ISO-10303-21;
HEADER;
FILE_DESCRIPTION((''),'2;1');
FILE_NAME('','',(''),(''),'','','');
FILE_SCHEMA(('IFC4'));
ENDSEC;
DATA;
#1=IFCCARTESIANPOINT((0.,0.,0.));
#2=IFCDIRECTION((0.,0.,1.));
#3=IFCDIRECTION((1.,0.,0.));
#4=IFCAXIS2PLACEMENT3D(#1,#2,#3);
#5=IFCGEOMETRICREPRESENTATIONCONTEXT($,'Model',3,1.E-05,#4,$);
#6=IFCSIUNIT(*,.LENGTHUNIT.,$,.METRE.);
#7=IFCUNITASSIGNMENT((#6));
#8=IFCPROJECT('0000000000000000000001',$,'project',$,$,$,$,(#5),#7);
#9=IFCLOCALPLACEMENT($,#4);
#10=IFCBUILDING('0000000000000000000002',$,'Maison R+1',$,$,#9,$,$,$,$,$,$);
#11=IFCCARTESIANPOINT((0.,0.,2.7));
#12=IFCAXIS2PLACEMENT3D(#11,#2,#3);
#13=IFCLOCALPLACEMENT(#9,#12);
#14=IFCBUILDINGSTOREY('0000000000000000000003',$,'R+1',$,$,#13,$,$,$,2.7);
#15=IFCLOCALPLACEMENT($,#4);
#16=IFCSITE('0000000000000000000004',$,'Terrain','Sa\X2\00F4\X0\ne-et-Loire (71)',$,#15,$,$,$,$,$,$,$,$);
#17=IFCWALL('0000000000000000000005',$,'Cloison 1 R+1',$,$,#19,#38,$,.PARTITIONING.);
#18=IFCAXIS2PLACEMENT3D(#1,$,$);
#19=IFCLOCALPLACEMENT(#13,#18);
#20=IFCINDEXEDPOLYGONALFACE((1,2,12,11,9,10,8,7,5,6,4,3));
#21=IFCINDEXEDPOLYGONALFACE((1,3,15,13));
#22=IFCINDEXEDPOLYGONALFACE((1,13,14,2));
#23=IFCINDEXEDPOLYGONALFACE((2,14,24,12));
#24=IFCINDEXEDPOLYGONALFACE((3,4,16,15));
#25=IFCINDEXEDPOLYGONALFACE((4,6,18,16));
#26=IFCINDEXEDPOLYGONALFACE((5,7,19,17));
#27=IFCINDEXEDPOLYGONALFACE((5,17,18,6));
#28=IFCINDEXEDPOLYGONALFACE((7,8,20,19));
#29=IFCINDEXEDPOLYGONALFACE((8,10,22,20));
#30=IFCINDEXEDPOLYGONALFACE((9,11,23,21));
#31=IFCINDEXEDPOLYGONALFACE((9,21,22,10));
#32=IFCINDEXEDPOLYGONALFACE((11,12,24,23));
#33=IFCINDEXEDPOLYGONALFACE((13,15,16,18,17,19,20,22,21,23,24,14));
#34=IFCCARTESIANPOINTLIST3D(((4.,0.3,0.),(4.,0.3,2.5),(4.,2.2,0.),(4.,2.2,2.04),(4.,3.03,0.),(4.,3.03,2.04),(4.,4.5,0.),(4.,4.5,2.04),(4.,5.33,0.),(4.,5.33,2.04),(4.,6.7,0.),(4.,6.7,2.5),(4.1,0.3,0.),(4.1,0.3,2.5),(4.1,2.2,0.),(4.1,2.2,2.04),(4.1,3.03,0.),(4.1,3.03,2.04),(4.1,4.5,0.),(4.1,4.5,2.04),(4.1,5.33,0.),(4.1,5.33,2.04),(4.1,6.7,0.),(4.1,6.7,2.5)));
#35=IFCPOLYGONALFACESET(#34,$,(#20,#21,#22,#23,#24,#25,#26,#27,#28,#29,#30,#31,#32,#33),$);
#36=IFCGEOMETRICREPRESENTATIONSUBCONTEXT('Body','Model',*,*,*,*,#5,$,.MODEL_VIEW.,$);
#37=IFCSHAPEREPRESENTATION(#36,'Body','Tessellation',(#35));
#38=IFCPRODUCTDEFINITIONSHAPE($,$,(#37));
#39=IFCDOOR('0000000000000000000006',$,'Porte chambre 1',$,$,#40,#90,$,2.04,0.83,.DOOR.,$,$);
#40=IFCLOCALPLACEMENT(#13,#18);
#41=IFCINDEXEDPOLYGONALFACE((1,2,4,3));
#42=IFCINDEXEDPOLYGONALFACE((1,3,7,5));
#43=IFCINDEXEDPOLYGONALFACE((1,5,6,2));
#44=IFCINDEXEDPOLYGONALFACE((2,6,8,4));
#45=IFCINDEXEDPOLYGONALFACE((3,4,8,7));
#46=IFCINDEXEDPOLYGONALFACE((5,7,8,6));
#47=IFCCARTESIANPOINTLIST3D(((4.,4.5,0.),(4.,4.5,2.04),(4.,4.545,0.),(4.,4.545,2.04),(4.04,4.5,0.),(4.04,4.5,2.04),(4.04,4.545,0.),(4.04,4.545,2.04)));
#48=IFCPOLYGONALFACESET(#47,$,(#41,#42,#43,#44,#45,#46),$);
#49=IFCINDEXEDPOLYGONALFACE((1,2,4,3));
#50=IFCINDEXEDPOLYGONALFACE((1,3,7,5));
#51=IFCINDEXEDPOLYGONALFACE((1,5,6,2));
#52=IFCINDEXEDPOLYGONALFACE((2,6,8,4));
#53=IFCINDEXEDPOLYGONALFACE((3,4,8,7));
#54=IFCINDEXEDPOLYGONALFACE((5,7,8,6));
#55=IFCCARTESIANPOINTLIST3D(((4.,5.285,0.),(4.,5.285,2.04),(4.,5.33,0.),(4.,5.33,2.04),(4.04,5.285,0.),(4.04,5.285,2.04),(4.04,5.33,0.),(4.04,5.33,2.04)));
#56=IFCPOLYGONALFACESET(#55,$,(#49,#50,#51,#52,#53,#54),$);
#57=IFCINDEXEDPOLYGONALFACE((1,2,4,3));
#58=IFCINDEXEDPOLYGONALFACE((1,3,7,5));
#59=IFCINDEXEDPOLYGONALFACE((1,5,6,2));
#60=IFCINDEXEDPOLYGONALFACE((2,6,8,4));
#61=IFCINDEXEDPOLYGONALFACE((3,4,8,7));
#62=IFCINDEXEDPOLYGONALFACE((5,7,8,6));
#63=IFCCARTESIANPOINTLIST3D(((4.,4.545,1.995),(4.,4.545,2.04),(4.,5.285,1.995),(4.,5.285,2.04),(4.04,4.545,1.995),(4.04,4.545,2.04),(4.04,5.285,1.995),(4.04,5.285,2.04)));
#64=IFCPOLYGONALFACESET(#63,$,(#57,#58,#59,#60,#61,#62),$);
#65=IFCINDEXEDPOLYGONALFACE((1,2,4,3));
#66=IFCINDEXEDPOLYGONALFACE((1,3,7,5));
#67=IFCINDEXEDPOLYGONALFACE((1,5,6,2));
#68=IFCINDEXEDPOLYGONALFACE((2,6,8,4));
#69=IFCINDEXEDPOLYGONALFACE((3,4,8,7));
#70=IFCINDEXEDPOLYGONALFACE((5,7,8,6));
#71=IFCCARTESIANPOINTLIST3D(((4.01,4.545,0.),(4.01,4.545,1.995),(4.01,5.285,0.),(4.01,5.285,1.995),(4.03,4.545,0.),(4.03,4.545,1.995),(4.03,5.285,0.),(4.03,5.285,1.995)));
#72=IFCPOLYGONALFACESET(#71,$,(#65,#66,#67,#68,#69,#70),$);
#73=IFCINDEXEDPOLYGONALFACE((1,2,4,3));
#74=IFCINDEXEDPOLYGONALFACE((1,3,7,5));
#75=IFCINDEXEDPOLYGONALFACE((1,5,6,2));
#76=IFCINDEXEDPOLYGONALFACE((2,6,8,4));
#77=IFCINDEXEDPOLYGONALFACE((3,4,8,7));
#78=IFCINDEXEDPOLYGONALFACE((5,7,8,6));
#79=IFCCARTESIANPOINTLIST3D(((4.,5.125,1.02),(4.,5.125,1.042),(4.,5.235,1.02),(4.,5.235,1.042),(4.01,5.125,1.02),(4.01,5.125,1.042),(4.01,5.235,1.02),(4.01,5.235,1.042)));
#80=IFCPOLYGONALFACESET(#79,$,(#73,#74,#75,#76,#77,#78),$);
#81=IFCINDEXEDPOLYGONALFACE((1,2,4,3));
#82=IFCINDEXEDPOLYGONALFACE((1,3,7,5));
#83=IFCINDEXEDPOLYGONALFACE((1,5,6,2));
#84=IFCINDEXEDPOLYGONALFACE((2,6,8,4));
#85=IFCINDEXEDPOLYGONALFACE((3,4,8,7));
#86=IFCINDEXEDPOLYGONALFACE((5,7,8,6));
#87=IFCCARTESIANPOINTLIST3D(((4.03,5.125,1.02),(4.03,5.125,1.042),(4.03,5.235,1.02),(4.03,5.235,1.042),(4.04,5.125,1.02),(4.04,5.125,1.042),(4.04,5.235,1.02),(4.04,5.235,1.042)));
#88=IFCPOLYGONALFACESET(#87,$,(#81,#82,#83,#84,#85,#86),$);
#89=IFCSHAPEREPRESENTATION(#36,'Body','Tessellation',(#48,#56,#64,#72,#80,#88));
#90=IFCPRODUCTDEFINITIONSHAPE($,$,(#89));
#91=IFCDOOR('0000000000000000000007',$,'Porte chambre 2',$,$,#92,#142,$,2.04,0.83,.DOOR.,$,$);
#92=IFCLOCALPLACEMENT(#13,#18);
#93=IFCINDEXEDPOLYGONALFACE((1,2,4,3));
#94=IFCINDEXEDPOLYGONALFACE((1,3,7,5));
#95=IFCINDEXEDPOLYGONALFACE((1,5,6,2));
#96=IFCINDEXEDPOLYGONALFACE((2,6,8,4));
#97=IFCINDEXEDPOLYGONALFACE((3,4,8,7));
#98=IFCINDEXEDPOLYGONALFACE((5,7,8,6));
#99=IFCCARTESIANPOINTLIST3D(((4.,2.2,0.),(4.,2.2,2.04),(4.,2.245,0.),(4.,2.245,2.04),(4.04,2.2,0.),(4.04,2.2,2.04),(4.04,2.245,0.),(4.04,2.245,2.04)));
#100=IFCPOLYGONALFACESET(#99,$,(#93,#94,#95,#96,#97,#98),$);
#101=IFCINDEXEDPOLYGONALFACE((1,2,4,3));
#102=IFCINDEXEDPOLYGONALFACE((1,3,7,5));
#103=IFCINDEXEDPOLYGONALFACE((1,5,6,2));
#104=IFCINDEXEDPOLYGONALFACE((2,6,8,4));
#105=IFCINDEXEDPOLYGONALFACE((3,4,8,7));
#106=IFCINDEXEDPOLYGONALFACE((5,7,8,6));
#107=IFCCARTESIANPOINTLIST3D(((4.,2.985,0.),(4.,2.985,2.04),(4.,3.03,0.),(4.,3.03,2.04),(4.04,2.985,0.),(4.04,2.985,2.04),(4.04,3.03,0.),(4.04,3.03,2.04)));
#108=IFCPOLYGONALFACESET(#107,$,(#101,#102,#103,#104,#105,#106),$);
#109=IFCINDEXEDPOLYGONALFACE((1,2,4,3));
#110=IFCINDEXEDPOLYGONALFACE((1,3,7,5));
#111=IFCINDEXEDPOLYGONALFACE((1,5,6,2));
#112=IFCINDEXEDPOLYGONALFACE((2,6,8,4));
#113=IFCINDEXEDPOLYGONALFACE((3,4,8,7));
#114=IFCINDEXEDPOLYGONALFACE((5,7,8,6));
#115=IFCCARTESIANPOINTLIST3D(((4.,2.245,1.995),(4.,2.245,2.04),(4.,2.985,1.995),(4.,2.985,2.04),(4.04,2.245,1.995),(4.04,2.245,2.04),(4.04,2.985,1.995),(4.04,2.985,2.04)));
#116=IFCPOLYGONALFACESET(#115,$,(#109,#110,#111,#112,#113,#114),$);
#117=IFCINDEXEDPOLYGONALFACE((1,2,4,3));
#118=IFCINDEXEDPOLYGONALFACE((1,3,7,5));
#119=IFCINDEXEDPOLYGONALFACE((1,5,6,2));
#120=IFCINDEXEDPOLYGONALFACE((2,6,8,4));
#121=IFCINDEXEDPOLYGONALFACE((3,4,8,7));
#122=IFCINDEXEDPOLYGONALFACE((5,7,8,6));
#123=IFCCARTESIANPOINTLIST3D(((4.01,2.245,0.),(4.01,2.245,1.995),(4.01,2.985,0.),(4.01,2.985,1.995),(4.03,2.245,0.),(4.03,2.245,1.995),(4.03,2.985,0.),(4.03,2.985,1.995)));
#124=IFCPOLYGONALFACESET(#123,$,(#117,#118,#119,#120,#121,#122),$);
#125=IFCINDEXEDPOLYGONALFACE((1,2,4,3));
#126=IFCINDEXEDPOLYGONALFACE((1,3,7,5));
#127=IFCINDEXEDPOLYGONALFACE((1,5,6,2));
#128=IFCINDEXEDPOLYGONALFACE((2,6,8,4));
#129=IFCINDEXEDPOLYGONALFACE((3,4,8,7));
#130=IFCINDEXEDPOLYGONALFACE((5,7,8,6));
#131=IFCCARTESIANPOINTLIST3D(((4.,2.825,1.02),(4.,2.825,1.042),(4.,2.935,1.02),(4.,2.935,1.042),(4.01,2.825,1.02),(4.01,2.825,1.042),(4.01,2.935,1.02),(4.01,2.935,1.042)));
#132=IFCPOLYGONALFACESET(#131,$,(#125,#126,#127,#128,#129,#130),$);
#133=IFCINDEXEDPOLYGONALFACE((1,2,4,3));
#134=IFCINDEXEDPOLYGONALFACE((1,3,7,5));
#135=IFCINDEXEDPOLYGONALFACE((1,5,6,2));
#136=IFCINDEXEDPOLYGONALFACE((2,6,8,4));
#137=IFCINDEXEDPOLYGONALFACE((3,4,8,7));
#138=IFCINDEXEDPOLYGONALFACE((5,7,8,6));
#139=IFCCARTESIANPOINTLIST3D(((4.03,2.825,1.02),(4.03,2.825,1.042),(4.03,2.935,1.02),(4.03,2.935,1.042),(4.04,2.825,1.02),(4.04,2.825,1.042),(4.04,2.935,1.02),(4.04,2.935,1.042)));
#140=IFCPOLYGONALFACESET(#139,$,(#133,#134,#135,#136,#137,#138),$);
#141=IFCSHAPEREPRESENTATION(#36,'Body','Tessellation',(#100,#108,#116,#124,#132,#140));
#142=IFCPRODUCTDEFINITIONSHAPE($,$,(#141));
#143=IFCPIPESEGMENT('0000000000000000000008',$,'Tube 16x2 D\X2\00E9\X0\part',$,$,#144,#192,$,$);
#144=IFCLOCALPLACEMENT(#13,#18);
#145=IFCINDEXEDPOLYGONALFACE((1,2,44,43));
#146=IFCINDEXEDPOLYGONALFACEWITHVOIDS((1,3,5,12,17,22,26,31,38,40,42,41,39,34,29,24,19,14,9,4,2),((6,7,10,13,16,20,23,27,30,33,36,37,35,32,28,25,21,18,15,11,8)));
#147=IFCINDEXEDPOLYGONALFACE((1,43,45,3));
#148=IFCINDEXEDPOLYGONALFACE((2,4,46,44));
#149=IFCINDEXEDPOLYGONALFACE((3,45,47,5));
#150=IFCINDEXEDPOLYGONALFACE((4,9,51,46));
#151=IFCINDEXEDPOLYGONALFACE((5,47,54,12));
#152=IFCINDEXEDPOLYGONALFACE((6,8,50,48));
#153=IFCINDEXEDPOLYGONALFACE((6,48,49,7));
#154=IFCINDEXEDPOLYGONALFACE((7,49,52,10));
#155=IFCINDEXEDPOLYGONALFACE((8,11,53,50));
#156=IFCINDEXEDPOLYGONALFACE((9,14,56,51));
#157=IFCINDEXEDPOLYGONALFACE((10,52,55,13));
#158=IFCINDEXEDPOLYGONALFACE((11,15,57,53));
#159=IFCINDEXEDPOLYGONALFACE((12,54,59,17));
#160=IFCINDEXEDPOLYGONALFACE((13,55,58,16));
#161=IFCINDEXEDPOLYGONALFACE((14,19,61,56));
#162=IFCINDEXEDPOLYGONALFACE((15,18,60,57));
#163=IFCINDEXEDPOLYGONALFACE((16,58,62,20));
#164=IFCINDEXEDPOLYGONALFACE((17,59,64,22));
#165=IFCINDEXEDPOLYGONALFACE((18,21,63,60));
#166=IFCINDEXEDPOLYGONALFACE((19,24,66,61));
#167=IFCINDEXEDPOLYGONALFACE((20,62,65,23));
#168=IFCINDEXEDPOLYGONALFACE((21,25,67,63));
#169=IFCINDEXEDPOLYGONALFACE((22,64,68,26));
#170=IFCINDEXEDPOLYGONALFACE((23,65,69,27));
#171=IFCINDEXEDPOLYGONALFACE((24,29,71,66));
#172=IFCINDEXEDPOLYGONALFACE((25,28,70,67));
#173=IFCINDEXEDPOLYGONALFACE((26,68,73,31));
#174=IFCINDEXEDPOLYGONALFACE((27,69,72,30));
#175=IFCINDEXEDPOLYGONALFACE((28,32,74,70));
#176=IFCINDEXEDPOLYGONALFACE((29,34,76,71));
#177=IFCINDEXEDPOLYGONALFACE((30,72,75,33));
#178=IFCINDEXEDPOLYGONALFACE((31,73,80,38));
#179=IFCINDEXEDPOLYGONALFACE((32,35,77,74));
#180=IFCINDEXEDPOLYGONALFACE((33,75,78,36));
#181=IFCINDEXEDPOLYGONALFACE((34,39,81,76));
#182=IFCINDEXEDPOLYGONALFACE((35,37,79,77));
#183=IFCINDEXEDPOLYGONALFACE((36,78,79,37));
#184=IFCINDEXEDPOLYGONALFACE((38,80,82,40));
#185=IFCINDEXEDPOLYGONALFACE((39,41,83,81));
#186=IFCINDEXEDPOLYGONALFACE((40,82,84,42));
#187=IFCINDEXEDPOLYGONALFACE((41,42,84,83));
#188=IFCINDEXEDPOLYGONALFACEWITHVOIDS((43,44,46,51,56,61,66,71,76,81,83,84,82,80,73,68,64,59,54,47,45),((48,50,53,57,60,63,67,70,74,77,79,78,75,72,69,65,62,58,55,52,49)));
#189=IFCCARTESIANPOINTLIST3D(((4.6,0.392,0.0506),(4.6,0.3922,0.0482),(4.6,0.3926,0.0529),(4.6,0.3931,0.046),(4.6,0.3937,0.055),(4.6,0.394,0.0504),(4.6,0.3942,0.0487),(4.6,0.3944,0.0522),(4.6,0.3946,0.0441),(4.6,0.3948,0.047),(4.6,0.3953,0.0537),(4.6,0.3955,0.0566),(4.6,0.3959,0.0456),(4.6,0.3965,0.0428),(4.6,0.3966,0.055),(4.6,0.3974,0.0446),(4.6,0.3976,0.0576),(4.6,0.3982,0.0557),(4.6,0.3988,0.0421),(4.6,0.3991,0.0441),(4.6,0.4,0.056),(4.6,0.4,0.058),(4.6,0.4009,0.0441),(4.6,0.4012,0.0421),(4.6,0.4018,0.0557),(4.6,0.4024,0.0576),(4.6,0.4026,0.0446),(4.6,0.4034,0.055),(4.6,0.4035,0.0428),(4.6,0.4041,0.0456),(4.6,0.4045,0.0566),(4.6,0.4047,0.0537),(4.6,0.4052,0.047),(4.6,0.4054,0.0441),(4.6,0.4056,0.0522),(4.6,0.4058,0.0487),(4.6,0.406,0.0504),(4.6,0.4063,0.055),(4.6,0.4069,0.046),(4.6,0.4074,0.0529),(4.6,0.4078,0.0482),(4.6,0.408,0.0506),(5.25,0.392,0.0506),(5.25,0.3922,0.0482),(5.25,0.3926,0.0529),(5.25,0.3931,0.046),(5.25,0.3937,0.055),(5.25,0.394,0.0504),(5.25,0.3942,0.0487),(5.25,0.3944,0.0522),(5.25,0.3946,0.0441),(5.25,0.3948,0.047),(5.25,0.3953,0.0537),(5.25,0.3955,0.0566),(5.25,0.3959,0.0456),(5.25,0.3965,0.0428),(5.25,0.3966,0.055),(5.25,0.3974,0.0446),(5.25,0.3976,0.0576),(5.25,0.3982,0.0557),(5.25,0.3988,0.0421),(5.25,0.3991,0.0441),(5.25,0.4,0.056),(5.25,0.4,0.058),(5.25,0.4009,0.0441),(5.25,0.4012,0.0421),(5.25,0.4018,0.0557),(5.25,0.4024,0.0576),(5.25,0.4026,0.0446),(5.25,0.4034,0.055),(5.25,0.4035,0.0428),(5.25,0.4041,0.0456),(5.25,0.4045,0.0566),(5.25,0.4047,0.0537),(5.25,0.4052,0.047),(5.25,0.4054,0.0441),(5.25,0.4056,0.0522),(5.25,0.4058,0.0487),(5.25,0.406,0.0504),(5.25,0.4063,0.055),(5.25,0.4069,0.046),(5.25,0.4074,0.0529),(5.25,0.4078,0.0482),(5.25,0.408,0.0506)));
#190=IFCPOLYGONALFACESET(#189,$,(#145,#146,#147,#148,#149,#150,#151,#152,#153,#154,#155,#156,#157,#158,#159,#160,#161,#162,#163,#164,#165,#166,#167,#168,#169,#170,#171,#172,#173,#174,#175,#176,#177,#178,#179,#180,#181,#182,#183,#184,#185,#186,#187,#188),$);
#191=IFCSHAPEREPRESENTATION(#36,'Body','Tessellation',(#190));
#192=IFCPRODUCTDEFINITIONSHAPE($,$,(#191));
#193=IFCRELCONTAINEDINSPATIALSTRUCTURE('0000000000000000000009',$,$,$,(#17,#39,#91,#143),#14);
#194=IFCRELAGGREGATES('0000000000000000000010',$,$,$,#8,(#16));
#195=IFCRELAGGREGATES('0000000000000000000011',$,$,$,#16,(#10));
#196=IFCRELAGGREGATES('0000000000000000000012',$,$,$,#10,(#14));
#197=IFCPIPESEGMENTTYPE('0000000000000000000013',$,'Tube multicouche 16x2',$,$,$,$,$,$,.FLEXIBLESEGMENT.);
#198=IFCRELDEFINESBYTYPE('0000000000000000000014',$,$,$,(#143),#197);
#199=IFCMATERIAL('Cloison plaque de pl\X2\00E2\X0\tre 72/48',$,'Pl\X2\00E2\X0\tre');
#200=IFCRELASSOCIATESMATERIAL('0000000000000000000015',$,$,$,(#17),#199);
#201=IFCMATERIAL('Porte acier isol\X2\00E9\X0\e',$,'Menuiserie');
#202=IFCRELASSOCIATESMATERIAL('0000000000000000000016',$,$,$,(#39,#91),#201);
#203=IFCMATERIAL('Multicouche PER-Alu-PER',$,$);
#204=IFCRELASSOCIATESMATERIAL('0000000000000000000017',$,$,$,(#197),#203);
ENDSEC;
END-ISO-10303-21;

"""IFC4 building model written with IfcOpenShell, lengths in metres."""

from ifc_helpers import new_model, si_unit, frame, frame_2d, origin_with_axes, place, context, subcontext, project, spatial, rectangle, hollow_circle, extrude, material, type_object, element, fill, save


model = new_model("IFC4")

# Units and contexts
model_context = context("Model", 3, precision=1e-05, world=origin_with_axes())
body_context = subcontext(model_context, "Body", "Model", "MODEL_VIEW")
ifc_project = project(units=[si_unit("LENGTHUNIT", "METRE")], contexts=[model_context])

# Site, building, storey
site_placement = place(None, origin_with_axes())
site = spatial("IfcSite", under=ifc_project, at=site_placement, Name="Terrain", Description="Saône-et-Loire (71)")
building_placement = place(None, origin_with_axes())
building = spatial("IfcBuilding", under=site, at=building_placement, Name="Maison R+1")
storey_placement = place(building_placement, frame((0.0, 0.0, 2.7), z_axis=(0.0, 0.0, 1.0), x_axis=(1.0, 0.0, 0.0)))
storey = spatial("IfcBuildingStorey", under=building, at=storey_placement, Name="R+1", Elevation=2.7)

# Wall, openings, doors
ifc_material_1 = material(Name="Cloison plaque de plâtre 72/48", Category="Plâtre")
wall_1_placement = place(storey_placement, frame((4.0, 0.3, 0.0), z_axis=(0.0, 0.0, 1.0), x_axis=(1.0, 0.0, 0.0)))
wall_1 = element("IfcWall", 1, at=wall_1_placement, inside=storey, material=ifc_material_1, Name="Cloison 1 R+1", PredefinedType="PARTITIONING", context=body_context, shape_type="SweptSolid", body=[
    extrude(rectangle(XDim=0.1, YDim=6.4, at=frame_2d((0.05, 3.2))), origin_with_axes(), (0.0, 0.0, 1.0), 2.5),
])
opening_1_placement = place(storey_placement, frame((3.95, 4.5, 0.0), z_axis=(0.0, 0.0, 1.0), x_axis=(1.0, 0.0, 0.0)))
opening_1 = element("IfcOpeningElement", 2, at=opening_1_placement, cuts=wall_1, context=body_context, shape_type="SweptSolid", body=[
    extrude(rectangle(XDim=0.2, YDim=0.83, at=frame_2d((0.1, 0.415))), origin_with_axes(), (0.0, 0.0, 1.0), 2.04),
])
opening_2_placement = place(storey_placement, frame((3.95, 2.2, 0.0), z_axis=(0.0, 0.0, 1.0), x_axis=(1.0, 0.0, 0.0)))
opening_2 = element("IfcOpeningElement", 3, at=opening_2_placement, cuts=wall_1, context=body_context, shape_type="SweptSolid", body=[
    extrude(rectangle(XDim=0.2, YDim=0.83, at=frame_2d((0.1, 0.415))), origin_with_axes(), (0.0, 0.0, 1.0), 2.04),
])
ifc_material_2 = material(Name="Porte acier isolée", Category="Menuiserie")
door_1_placement = place(storey_placement, frame((4.0, 4.5, 0.0), z_axis=(0.0, 0.0, 1.0), x_axis=(1.0, 0.0, 0.0)))
door_1 = element("IfcDoor", 4, at=door_1_placement, inside=storey, material=ifc_material_2, Name="Porte chambre 1", OverallHeight=2.04, OverallWidth=0.83, PredefinedType="DOOR", context=body_context, shape_type="SweptSolid", body=[
    extrude(rectangle(XDim=0.04, YDim=0.045, at=frame_2d((0.02, 0.0225))), origin_with_axes(), (0.0, 0.0, 1.0), 2.04),
    extrude(rectangle(XDim=0.04, YDim=0.045, at=frame_2d((0.02, 0.0225))), frame((0.0, 0.785, 0.0), z_axis=(0.0, 0.0, 1.0), x_axis=(1.0, 0.0, 0.0)), (0.0, 0.0, 1.0), 2.04),
    extrude(rectangle(XDim=0.04, YDim=0.74, at=frame_2d((0.02, 0.37))), frame((0.0, 0.045, 1.995), z_axis=(0.0, 0.0, 1.0), x_axis=(1.0, 0.0, 0.0)), (0.0, 0.0, 1.0), 0.045),
    extrude(rectangle(XDim=0.02, YDim=0.74, at=frame_2d((0.01, 0.37))), frame((0.01, 0.045, 0.0), z_axis=(0.0, 0.0, 1.0), x_axis=(1.0, 0.0, 0.0)), (0.0, 0.0, 1.0), 1.995),
    extrude(rectangle(XDim=0.01, YDim=0.11, at=frame_2d((0.005, 0.055))), frame((0.0, 0.625, 1.02), z_axis=(0.0, 0.0, 1.0), x_axis=(1.0, 0.0, 0.0)), (0.0, 0.0, 1.0), 0.022),
    extrude(rectangle(XDim=0.01, YDim=0.11, at=frame_2d((0.005, 0.055))), frame((0.03, 0.625, 1.02), z_axis=(0.0, 0.0, 1.0), x_axis=(1.0, 0.0, 0.0)), (0.0, 0.0, 1.0), 0.022),
])
fill(opening_1, door_1)
door_2_placement = place(storey_placement, frame((4.0, 2.2, 0.0), z_axis=(0.0, 0.0, 1.0), x_axis=(1.0, 0.0, 0.0)))
door_2 = element("IfcDoor", 5, at=door_2_placement, inside=storey, material=ifc_material_2, Name="Porte chambre 2", OverallHeight=2.04, OverallWidth=0.83, PredefinedType="DOOR", context=body_context, shape_type="SweptSolid", body=[
    extrude(rectangle(XDim=0.04, YDim=0.045, at=frame_2d((0.02, 0.0225))), origin_with_axes(), (0.0, 0.0, 1.0), 2.04),
    extrude(rectangle(XDim=0.04, YDim=0.045, at=frame_2d((0.02, 0.0225))), frame((0.0, 0.785, 0.0), z_axis=(0.0, 0.0, 1.0), x_axis=(1.0, 0.0, 0.0)), (0.0, 0.0, 1.0), 2.04),
    extrude(rectangle(XDim=0.04, YDim=0.74, at=frame_2d((0.02, 0.37))), frame((0.0, 0.045, 1.995), z_axis=(0.0, 0.0, 1.0), x_axis=(1.0, 0.0, 0.0)), (0.0, 0.0, 1.0), 0.045),
    extrude(rectangle(XDim=0.02, YDim=0.74, at=frame_2d((0.01, 0.37))), frame((0.01, 0.045, 0.0), z_axis=(0.0, 0.0, 1.0), x_axis=(1.0, 0.0, 0.0)), (0.0, 0.0, 1.0), 1.995),
    extrude(rectangle(XDim=0.01, YDim=0.11, at=frame_2d((0.005, 0.055))), frame((0.0, 0.625, 1.02), z_axis=(0.0, 0.0, 1.0), x_axis=(1.0, 0.0, 0.0)), (0.0, 0.0, 1.0), 0.022),
    extrude(rectangle(XDim=0.01, YDim=0.11, at=frame_2d((0.005, 0.055))), frame((0.03, 0.625, 1.02), z_axis=(0.0, 0.0, 1.0), x_axis=(1.0, 0.0, 0.0)), (0.0, 0.0, 1.0), 0.022),
])
fill(opening_2, door_2)

# Pipe segment
ifc_material_3 = material(Name="Multicouche PER-Alu-PER")
pipe_segment_type = type_object("IfcPipeSegmentType", Name="Tube multicouche 16x2", PredefinedType="FLEXIBLESEGMENT", material=ifc_material_3)
pipe_segment_1_placement = place(storey_placement, frame((4.6, 0.4, 0.05), z_axis=(1.0, 0.0, 0.0), x_axis=(0.0, 0.0, 1.0)))
element("IfcPipeSegment", 6, at=pipe_segment_1_placement, inside=storey, type_object=pipe_segment_type, Name="Tube 16x2 Départ", context=body_context, shape_type="SweptSolid", body=[
    extrude(hollow_circle(Radius=0.008, WallThickness=0.002), origin_with_axes(), (0.0, 0.0, 1.0), 0.65),
])

save(model, "model.ifc")
